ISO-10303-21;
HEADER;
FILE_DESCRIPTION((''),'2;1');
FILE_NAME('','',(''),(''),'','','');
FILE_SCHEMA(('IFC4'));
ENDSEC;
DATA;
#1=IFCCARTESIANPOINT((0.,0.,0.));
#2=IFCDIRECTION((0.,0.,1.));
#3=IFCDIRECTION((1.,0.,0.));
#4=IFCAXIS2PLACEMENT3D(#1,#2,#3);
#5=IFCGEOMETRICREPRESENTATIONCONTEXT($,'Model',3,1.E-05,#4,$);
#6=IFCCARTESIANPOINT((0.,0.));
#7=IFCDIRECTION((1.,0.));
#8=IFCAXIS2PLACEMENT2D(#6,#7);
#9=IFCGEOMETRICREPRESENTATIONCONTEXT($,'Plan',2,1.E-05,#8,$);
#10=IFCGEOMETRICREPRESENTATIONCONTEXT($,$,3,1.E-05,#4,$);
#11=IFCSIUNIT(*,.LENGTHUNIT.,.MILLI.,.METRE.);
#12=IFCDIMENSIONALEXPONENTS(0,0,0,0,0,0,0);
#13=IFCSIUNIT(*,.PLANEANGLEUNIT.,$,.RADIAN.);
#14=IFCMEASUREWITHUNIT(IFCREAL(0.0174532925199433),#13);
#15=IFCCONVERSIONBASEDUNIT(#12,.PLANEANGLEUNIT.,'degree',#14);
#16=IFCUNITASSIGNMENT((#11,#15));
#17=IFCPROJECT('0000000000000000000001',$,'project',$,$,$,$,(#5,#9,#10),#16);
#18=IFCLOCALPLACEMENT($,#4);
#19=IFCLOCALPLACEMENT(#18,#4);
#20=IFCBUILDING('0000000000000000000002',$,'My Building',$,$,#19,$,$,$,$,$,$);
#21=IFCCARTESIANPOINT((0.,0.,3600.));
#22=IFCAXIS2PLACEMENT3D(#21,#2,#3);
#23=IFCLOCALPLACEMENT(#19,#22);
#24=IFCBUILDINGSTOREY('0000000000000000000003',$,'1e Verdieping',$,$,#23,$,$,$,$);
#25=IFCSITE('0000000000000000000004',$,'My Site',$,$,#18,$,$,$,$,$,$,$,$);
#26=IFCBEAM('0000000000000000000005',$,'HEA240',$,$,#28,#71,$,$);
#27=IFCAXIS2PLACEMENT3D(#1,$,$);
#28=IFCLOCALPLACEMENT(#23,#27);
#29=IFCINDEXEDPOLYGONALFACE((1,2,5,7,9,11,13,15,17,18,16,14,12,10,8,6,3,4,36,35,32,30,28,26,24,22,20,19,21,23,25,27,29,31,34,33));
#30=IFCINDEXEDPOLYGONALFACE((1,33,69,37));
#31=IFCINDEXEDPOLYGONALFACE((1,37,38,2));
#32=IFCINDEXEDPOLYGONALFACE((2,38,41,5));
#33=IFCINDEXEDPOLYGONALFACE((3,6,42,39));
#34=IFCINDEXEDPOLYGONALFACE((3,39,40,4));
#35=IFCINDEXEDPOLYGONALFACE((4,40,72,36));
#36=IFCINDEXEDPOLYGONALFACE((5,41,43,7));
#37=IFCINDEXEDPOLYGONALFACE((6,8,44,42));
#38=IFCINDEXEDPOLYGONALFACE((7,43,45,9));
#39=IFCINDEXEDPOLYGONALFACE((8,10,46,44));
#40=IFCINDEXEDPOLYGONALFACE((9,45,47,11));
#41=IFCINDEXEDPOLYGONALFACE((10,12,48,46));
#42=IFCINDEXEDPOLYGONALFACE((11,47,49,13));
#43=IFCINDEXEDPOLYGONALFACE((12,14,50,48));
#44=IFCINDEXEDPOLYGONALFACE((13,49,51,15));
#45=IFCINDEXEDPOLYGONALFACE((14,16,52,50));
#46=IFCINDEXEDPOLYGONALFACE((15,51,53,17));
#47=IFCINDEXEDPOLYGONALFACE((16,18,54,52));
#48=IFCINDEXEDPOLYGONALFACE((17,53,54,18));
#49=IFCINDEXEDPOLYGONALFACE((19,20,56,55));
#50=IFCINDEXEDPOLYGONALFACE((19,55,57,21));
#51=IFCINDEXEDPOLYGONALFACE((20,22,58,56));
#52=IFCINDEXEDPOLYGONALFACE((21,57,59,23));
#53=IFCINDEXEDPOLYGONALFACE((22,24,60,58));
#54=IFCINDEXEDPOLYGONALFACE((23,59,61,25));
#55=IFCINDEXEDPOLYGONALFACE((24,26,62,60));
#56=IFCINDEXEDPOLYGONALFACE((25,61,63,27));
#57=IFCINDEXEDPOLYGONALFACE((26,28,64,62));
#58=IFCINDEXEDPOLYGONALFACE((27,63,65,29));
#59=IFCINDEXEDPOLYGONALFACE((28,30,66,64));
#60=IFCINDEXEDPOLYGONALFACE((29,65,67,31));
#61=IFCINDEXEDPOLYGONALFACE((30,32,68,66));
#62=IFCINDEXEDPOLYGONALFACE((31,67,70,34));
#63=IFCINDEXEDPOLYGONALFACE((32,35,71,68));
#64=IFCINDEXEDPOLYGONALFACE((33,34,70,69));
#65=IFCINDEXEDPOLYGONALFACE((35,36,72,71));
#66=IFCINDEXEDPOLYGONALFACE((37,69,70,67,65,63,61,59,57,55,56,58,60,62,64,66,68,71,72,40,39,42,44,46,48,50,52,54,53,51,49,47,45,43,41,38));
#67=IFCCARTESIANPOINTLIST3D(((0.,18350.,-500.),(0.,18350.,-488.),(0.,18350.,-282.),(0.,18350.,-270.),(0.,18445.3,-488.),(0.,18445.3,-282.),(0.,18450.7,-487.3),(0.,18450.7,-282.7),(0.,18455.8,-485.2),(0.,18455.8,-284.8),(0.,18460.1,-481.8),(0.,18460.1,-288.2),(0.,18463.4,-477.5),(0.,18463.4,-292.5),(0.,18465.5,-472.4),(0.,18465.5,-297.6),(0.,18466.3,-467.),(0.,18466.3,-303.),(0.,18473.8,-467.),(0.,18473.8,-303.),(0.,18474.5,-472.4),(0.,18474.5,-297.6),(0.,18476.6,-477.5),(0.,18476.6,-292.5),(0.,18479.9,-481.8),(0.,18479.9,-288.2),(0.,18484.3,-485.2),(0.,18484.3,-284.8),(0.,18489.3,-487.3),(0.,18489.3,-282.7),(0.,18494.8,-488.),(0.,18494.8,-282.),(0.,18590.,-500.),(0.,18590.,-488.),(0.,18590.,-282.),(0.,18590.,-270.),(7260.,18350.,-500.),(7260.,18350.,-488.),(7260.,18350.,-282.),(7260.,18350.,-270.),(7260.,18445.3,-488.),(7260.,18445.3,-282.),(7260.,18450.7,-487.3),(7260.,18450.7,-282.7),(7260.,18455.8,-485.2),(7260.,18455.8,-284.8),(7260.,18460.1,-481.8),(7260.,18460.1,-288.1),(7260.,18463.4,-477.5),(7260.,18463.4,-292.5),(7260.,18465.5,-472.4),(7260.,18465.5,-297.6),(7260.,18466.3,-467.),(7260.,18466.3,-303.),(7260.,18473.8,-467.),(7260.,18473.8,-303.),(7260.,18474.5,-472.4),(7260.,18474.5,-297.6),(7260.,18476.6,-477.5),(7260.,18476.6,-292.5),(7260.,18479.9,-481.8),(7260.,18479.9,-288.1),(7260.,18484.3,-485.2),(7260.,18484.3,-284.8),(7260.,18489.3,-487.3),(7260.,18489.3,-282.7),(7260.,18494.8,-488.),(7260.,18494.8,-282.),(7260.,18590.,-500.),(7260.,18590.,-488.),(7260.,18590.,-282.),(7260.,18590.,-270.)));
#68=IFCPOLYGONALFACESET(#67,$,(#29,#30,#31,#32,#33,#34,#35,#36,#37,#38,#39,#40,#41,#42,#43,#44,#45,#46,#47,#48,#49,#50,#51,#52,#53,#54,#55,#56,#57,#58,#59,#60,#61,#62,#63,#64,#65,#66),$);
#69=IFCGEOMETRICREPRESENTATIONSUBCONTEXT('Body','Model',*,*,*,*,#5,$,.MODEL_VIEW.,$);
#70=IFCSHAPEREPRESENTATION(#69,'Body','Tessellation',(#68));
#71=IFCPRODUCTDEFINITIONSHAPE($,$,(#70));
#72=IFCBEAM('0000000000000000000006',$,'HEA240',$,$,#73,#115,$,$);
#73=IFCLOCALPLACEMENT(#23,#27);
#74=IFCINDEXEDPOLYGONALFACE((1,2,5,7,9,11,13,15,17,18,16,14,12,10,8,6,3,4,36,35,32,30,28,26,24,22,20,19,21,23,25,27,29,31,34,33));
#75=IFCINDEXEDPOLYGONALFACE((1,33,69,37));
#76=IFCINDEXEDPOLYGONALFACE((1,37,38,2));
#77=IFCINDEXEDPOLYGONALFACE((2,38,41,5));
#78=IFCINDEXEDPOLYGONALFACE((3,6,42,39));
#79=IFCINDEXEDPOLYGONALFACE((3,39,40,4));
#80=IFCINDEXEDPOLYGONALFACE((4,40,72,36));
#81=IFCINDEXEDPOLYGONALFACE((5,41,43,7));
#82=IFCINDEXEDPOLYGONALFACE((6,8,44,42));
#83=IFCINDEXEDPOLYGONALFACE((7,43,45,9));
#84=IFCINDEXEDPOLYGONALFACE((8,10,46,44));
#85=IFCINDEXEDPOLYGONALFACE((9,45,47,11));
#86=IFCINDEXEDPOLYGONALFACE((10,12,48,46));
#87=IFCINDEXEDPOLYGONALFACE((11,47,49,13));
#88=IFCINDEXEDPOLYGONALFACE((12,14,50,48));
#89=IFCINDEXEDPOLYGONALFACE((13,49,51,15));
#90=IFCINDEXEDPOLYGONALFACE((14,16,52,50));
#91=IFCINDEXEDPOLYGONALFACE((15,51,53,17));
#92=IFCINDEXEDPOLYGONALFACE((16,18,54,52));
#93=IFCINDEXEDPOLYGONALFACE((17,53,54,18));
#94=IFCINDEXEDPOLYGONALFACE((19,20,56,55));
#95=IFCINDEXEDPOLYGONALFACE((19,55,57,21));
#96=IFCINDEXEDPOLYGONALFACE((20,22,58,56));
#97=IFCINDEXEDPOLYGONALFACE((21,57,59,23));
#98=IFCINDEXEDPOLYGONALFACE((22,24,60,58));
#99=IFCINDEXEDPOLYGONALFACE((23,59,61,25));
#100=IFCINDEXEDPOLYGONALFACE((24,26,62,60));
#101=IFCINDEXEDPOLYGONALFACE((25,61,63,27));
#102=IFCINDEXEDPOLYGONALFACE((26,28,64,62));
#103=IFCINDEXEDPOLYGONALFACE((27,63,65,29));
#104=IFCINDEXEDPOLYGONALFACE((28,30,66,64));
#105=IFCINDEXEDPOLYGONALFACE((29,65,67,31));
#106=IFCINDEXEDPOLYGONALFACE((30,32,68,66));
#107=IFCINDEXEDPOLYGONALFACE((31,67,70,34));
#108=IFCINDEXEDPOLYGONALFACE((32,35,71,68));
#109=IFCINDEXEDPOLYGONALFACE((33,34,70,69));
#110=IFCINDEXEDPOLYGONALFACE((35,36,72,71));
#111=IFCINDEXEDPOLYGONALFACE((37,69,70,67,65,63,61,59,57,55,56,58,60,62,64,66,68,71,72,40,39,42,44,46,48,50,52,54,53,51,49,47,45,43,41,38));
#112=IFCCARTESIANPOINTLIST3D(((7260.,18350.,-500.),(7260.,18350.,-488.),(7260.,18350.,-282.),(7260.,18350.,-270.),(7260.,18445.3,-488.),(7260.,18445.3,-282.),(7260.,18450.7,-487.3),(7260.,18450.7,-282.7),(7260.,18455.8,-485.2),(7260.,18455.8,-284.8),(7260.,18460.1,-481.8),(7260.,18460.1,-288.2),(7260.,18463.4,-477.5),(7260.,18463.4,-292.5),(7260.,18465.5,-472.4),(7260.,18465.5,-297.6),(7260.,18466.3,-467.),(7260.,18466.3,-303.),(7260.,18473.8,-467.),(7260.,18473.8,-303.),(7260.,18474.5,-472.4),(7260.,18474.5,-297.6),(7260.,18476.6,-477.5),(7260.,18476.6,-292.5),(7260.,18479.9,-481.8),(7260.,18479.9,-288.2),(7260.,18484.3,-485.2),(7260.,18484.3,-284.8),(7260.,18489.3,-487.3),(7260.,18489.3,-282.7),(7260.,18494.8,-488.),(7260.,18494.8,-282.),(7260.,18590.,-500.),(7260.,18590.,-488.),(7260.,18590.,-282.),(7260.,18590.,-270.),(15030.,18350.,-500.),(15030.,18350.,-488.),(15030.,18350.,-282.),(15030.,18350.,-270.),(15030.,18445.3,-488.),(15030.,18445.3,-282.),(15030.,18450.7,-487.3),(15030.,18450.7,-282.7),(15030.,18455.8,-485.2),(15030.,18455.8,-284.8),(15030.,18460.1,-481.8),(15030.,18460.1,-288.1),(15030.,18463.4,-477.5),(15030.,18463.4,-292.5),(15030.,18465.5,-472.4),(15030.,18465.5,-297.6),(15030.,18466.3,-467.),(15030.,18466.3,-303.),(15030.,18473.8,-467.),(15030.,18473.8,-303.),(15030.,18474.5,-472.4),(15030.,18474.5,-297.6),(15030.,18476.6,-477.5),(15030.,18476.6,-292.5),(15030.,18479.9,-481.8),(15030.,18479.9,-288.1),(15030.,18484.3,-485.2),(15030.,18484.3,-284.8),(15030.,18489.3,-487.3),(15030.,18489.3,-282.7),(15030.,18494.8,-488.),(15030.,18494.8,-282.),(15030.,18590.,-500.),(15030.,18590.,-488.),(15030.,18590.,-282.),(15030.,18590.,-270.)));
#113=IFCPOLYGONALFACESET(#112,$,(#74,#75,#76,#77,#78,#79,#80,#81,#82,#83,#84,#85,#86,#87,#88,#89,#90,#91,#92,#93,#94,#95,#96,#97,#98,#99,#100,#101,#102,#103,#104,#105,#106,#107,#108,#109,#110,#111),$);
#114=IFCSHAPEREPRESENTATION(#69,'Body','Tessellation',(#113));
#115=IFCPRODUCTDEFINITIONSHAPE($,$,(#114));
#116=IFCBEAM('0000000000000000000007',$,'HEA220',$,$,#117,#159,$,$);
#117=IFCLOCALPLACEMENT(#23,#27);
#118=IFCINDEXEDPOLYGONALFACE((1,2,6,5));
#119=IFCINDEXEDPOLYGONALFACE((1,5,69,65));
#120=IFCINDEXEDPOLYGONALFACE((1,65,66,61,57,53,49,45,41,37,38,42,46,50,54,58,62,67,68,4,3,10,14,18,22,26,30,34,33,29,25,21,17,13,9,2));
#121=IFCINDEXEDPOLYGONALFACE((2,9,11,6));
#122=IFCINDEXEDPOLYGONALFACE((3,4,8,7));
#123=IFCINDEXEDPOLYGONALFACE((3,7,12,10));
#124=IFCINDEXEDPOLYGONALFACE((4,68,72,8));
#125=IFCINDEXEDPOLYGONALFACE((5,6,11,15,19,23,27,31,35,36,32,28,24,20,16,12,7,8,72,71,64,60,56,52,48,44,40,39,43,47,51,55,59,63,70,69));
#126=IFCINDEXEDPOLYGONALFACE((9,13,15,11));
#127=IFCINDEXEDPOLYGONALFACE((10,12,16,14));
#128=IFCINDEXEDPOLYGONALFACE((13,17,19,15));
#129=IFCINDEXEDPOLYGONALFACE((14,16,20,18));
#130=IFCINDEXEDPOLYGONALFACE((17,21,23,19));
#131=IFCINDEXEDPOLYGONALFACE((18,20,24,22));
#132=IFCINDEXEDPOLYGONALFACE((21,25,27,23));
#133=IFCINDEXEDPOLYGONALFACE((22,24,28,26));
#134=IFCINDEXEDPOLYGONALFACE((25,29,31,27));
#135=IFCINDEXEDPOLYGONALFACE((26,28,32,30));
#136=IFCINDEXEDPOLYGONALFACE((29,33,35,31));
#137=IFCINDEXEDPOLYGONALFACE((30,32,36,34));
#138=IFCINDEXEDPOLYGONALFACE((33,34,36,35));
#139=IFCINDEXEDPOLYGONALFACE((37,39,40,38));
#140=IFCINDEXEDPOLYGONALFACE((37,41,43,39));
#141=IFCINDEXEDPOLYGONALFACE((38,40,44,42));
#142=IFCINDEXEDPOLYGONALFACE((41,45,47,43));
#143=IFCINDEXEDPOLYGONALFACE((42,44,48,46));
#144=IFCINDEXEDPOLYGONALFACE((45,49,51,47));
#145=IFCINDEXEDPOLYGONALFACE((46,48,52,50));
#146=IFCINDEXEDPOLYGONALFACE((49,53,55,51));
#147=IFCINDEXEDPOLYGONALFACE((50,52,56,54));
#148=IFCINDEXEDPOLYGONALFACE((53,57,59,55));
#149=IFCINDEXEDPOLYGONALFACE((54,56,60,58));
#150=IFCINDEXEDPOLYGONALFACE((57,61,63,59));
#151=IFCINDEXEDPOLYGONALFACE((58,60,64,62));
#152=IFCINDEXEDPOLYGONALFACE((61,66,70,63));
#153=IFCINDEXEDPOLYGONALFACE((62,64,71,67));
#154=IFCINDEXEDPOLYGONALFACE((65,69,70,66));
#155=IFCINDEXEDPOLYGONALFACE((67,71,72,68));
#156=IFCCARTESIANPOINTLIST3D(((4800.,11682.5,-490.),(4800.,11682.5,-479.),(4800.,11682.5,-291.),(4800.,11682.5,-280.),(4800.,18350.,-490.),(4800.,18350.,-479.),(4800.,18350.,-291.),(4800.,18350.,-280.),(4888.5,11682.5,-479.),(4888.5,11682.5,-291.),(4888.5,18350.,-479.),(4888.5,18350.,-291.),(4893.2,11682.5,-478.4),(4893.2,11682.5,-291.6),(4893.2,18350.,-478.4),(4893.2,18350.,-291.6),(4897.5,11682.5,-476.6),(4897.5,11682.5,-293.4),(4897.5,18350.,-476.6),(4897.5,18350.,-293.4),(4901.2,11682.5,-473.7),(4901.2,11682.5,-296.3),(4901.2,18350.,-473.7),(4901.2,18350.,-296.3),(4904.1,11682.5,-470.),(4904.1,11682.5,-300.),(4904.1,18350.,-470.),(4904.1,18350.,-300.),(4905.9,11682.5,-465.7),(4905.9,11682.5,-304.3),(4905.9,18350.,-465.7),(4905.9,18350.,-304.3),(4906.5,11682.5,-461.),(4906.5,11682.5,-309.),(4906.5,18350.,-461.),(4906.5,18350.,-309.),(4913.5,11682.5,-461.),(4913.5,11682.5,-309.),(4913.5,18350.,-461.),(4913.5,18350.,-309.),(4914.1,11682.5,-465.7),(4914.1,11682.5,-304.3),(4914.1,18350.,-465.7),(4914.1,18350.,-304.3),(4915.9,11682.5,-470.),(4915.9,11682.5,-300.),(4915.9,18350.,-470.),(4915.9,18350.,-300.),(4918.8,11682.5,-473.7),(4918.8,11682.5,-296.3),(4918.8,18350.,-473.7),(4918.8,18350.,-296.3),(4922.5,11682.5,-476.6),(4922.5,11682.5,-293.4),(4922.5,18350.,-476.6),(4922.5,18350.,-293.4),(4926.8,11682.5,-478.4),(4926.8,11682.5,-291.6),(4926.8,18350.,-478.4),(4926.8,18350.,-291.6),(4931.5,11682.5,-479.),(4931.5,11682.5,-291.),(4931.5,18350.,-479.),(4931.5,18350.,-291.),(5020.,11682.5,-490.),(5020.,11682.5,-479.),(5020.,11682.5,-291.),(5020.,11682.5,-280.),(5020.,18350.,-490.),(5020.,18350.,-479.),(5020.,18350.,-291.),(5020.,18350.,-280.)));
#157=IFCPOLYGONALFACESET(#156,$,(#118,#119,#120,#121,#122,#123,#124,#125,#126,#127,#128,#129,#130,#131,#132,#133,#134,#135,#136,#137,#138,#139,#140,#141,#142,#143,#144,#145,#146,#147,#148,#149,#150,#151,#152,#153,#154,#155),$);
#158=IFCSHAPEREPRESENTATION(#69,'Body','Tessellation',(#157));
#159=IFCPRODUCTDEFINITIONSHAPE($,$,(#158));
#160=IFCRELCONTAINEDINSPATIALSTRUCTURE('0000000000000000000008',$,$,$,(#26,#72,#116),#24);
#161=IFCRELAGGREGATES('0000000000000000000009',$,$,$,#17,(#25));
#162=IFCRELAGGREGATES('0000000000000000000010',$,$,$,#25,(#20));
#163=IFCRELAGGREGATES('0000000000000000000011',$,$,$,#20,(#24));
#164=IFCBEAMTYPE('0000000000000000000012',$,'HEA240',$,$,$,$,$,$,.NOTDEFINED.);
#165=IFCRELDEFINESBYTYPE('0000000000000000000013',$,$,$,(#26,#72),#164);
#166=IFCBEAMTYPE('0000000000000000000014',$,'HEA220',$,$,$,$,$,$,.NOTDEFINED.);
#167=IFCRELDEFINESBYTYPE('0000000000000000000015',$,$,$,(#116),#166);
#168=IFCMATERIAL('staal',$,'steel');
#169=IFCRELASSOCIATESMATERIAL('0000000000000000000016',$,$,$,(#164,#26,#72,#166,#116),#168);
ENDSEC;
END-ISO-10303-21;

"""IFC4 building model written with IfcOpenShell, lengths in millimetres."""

from ifc_helpers import new_model, entity, si_unit, converted_unit, frame, origin_with_axes, origin_2d_with_axis, place, context, subcontext, project, spatial, i_section, extrude, material, material_profile, profile_set, profile_usage, type_object, element, save


model = new_model("IFC4")

# Units and contexts
model_context = context("Model", 3, precision=1e-05, world=origin_with_axes())
plan_context = context("Plan", 2, precision=1e-05, world=origin_2d_with_axis())
context_of_model = context(None, 3, precision=1e-05, world=origin_with_axes())
body_context = subcontext(model_context, "Body", "Model", "MODEL_VIEW")
ifc_project = project(units=[si_unit("LENGTHUNIT", "METRE", prefix="MILLI"), converted_unit("PLANEANGLEUNIT", "degree", entity("IfcReal", 0.0174532925199433), si_unit("PLANEANGLEUNIT", "RADIAN"), dimensions=[0, 0, 0, 0, 0, 0, 0])], contexts=[model_context, plan_context, context_of_model])

# Site, building, storey
site_placement = place(None, origin_with_axes())
site = spatial("IfcSite", under=ifc_project, at=site_placement, Name="My Site")
building_placement = place(site_placement, origin_with_axes())
building = spatial("IfcBuilding", under=site, at=building_placement, Name="My Building")
storey_placement = place(building_placement, frame((0.0, 0.0, 3600.0), z_axis=(0.0, 0.0, 1.0), x_axis=(1.0, 0.0, 0.0)))
storey = spatial("IfcBuildingStorey", under=building, at=storey_placement, Name="1e Verdieping")

# Shared definitions
ifc_material = material(Name="staal", Category="steel")

# Beams
ifc_material_profile_1 = material_profile(ifc_material, i_section(OverallWidth=240.0, OverallDepth=230.0, WebThickness=7.5, FlangeThickness=12.0, FilletRadius=21.0))
ifc_profile_set_1 = profile_set([ifc_material_profile_1], Name="HEA240")
ifc_profile_usage_1 = profile_usage(ifc_profile_set_1, cardinal=5)
beam_type_1 = type_object("IfcBeamType", Name="HEA240", PredefinedType="NOTDEFINED", material=ifc_profile_set_1)
beam_1_placement = place(storey_placement, frame((0.0, 18470.0, -385.0), z_axis=(1.0, 0.0, 0.0), x_axis=(0.0, 1.0, 0.0)))
element("IfcBeam", 1, at=beam_1_placement, inside=storey, type_object=beam_type_1, material=ifc_profile_usage_1, Name="HEA240", context=body_context, shape_type="SweptSolid", body=[
    extrude(i_section(OverallWidth=240.0, OverallDepth=230.0, WebThickness=7.5, FlangeThickness=12.0, FilletRadius=21.0), origin_with_axes(), (0.0, 0.0, 1.0), 7260.0),
])
ifc_profile_usage_2 = profile_usage(ifc_profile_set_1, cardinal=5)
beam_2_placement = place(storey_placement, frame((7260.0, 18470.0, -385.0), z_axis=(1.0, 0.0, 0.0), x_axis=(0.0, 1.0, 0.0)))
element("IfcBeam", 2, at=beam_2_placement, inside=storey, type_object=beam_type_1, material=ifc_profile_usage_2, Name="HEA240", context=body_context, shape_type="SweptSolid", body=[
    extrude(i_section(OverallWidth=240.0, OverallDepth=230.0, WebThickness=7.5, FlangeThickness=12.0, FilletRadius=21.0), origin_with_axes(), (0.0, 0.0, 1.0), 7770.0),
])
ifc_material_profile_2 = material_profile(ifc_material, i_section(OverallWidth=220.0, OverallDepth=210.0, WebThickness=7.0, FlangeThickness=11.0, FilletRadius=18.0))
ifc_profile_set_2 = profile_set([ifc_material_profile_2], Name="HEA220")
ifc_profile_usage_3 = profile_usage(ifc_profile_set_2)
beam_type_2 = type_object("IfcBeamType", Name="HEA220", PredefinedType="NOTDEFINED", material=ifc_profile_set_2)
beam_3_placement = place(storey_placement, frame((4910.0, 18350.0, -385.0), z_axis=(0.0, -1.0, 0.0), x_axis=(1.0, 0.0, 0.0)))
element("IfcBeam", 3, at=beam_3_placement, inside=storey, type_object=beam_type_2, material=ifc_profile_usage_3, Name="HEA220", context=body_context, shape_type="SweptSolid", body=[
    extrude(i_section(OverallWidth=220.0, OverallDepth=210.0, WebThickness=7.0, FlangeThickness=11.0, FilletRadius=18.0), origin_with_axes(), (0.0, 0.0, 1.0), 6667.5),
])

save(model, "model.ifc")
